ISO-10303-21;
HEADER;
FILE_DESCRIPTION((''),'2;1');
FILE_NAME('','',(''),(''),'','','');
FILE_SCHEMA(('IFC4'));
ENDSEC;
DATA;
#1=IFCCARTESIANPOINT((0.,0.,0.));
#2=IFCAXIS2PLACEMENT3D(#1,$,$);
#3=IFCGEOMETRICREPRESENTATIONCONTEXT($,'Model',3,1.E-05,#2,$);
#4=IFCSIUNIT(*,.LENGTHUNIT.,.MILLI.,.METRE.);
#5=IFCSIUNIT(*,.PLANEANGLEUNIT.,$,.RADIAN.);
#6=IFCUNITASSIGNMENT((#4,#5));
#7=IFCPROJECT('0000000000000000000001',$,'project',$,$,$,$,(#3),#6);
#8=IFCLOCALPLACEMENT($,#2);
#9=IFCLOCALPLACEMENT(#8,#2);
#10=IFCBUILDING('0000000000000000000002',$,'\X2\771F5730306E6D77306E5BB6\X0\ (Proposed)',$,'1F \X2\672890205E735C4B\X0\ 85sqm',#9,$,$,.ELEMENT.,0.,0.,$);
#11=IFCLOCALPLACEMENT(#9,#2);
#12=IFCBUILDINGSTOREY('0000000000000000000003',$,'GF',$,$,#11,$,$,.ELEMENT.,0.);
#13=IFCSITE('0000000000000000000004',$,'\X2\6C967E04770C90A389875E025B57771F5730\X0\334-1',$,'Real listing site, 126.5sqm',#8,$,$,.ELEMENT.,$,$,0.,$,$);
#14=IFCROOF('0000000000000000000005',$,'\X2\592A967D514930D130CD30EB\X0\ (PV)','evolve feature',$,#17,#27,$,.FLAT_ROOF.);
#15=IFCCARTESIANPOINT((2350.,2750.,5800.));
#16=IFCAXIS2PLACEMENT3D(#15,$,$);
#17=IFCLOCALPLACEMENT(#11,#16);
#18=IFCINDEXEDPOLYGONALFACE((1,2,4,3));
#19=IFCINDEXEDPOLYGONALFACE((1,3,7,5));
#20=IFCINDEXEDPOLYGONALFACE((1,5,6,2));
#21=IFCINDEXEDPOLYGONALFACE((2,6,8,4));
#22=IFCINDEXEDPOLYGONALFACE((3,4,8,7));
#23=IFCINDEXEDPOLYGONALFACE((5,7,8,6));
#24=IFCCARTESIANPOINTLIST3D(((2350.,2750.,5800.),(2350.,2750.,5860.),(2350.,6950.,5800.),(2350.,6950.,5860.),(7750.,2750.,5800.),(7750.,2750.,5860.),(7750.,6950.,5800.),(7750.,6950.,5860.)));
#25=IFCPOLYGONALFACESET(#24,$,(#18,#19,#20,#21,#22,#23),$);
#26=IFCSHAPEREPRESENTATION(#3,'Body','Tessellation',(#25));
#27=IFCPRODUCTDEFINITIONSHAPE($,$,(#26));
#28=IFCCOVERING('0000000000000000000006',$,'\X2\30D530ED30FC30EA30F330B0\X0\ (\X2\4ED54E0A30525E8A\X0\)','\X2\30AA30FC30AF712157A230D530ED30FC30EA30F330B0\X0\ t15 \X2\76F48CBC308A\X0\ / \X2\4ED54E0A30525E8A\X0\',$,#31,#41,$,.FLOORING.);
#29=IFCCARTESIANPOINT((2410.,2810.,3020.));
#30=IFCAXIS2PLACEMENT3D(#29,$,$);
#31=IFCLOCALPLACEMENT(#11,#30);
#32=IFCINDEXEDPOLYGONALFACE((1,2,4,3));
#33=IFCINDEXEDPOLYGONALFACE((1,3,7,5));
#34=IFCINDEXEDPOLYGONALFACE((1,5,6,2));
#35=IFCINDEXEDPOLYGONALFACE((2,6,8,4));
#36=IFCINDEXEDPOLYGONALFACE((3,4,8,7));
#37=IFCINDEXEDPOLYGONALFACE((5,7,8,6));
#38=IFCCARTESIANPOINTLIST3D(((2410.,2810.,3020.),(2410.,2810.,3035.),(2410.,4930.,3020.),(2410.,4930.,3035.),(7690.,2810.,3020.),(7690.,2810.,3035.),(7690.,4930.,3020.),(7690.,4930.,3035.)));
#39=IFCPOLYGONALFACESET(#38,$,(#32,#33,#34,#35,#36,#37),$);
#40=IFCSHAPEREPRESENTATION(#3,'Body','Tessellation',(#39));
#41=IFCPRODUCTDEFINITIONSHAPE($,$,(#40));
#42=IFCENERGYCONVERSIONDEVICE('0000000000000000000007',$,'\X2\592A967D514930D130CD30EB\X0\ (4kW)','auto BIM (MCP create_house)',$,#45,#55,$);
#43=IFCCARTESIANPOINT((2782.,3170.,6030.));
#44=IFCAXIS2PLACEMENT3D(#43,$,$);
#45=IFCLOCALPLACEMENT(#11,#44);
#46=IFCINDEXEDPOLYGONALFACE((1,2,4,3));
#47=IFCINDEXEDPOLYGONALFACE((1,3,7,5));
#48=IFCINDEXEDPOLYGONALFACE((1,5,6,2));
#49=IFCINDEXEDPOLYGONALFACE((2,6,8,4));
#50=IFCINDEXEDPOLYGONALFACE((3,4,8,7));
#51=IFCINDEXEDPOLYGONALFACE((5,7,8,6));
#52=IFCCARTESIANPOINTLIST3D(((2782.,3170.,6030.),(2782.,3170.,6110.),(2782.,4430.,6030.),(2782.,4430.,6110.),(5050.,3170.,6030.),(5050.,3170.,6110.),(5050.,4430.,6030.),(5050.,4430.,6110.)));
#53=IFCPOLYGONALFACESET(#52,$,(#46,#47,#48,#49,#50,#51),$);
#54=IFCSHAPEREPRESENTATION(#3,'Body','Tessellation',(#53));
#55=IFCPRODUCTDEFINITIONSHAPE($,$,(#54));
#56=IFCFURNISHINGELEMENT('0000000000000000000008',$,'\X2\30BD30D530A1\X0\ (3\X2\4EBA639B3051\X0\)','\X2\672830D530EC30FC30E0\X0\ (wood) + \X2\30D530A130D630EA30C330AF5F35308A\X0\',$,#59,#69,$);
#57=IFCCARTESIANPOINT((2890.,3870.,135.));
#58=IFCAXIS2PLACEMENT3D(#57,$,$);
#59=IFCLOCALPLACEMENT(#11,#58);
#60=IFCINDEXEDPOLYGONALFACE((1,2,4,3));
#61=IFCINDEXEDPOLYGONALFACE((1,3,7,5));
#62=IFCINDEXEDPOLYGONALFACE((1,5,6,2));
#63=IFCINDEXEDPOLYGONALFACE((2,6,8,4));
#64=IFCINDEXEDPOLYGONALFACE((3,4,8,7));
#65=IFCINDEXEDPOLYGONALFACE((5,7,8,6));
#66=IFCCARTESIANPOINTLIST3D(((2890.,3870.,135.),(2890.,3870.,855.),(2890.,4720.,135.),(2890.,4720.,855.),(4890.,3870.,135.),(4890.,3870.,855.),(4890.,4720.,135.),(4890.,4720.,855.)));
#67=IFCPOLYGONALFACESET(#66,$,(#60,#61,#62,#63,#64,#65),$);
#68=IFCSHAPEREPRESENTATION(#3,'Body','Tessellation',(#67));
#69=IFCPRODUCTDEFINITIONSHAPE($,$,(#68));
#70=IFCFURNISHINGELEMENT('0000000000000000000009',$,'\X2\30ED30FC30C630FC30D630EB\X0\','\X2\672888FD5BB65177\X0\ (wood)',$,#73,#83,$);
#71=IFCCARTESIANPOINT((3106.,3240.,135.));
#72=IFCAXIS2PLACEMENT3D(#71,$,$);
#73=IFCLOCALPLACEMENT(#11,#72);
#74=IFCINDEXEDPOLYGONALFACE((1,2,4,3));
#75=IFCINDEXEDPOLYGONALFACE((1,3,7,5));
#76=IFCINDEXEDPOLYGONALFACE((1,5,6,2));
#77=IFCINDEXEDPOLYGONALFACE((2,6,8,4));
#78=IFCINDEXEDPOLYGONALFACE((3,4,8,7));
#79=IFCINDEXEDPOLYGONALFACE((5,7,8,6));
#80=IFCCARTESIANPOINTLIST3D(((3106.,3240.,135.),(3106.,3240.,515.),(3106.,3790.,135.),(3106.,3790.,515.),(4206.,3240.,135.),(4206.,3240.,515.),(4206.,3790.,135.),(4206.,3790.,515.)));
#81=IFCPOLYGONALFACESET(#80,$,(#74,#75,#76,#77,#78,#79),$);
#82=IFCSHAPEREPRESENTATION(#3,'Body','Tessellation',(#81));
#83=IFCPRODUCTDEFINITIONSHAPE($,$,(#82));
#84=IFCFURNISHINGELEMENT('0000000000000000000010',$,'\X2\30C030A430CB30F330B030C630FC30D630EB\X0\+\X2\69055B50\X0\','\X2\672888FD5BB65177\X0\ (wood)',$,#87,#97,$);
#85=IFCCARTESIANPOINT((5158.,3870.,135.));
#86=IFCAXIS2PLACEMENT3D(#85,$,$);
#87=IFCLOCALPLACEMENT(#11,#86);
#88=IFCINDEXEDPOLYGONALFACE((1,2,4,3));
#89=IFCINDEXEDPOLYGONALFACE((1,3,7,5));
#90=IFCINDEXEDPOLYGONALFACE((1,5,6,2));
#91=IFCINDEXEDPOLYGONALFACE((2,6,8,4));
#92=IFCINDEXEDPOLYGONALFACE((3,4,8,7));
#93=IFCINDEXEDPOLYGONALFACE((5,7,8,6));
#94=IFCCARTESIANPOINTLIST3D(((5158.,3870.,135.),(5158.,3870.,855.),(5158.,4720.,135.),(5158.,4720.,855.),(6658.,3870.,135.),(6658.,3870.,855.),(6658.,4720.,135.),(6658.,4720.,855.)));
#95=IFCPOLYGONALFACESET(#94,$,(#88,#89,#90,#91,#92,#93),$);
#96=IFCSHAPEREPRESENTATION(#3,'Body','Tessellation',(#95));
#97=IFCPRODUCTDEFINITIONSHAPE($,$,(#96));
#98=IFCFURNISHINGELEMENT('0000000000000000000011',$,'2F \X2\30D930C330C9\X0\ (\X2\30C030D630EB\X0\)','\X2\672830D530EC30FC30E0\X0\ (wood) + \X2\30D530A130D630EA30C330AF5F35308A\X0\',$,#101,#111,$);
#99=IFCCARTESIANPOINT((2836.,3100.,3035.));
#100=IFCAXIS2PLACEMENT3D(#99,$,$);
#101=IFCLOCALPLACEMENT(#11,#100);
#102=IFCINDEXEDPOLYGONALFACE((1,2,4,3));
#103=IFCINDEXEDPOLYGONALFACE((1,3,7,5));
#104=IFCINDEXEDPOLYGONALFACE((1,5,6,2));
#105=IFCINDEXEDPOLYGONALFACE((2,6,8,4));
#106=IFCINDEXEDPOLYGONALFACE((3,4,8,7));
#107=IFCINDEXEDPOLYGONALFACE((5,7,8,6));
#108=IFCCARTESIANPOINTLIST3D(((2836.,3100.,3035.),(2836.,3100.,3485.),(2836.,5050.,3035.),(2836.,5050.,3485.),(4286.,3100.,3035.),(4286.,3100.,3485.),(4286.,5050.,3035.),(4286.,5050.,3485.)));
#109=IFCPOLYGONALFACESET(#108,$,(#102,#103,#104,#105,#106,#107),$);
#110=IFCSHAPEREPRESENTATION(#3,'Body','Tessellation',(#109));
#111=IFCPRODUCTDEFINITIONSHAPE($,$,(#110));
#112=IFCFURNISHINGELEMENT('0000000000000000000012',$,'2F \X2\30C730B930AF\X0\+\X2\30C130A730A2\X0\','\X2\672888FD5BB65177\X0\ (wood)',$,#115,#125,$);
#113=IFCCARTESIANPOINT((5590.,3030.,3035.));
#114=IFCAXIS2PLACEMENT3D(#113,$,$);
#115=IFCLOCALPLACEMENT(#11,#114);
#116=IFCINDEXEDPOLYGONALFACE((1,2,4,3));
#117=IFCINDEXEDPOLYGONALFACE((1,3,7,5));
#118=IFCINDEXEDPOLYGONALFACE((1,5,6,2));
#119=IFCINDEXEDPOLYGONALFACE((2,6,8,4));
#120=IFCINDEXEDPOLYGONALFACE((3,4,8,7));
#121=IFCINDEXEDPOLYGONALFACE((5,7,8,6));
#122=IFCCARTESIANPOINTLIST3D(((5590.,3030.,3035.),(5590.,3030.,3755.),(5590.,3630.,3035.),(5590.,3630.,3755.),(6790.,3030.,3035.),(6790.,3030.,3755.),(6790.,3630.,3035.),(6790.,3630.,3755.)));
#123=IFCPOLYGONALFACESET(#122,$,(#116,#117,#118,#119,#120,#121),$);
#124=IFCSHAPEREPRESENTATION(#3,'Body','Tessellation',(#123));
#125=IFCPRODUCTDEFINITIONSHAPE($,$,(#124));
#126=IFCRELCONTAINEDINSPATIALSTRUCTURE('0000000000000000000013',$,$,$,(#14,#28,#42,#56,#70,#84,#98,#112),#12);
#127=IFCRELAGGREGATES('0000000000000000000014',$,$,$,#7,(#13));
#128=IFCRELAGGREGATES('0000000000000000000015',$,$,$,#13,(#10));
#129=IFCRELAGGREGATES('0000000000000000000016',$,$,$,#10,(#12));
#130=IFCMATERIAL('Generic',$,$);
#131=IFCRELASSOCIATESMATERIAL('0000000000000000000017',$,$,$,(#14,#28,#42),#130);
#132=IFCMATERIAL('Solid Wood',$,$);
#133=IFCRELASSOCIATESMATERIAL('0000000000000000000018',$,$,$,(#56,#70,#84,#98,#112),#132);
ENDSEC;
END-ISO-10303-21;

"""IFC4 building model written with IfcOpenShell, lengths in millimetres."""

from ifc_helpers import new_model, si_unit, frame, frame_2d, origin, place, context, project, spatial, rectangle, extrude, material, element, save


model = new_model("IFC4")

# Units and contexts
model_context = context("Model", 3, precision=1e-05, world=origin())
ifc_project = project(units=[si_unit("LENGTHUNIT", "METRE", prefix="MILLI"), si_unit("PLANEANGLEUNIT", "RADIAN")], contexts=[model_context])

# Site, building, storey
site_placement = place(None, origin())
site = spatial("IfcSite", under=ifc_project, at=site_placement, Name="沖縄県那覇市字真地334-1", ObjectType="Real listing site, 126.5sqm", CompositionType="ELEMENT", RefElevation=0.0)
building_placement = place(site_placement, origin())
building = spatial("IfcBuilding", under=site, at=building_placement, Name="真地の海の家 (Proposed)", ObjectType="1F 木造平屋 85sqm", CompositionType="ELEMENT", ElevationOfRefHeight=0.0, ElevationOfTerrain=0.0)
storey_placement = place(building_placement, origin())
storey = spatial("IfcBuildingStorey", under=building, at=storey_placement, Name="GF", CompositionType="ELEMENT", Elevation=0.0)

# Shared definitions
ifc_material_1 = material(Name="Solid Wood")

# Roof
ifc_material_2 = material(Name="Generic")
roof_1_placement = place(storey_placement, frame((2350.0, 2750.0, 5800.0)))
element("IfcRoof", 1, at=roof_1_placement, inside=storey, material=ifc_material_2, Name="太陽光パネル (PV)", Description="evolve feature", PredefinedType="FLAT_ROOF", context=model_context, shape_type="SweptSolid", body=[
    extrude(rectangle(XDim=5400.0, YDim=4200.0, at=frame_2d((2700.0, 2100.0))), frame((2350.0, 2750.0, 5800.0)), (0.0, 0.0, 1.0), 60.0),
])

# Covering
covering_placement = place(storey_placement, frame((2410.0, 2810.0, 3020.0)))
element("IfcCovering", 2, at=covering_placement, inside=storey, material=ifc_material_2, Name="フローリング (仕上げ床)", Description="オーク無垢フローリング t15 直貼り / 仕上げ床", PredefinedType="FLOORING", context=model_context, shape_type="SweptSolid", body=[
    extrude(rectangle(XDim=5280.0, YDim=2120.0, at=frame_2d((2640.0, 1060.0))), frame((2410.0, 2810.0, 3020.0)), (0.0, 0.0, 1.0), 15.0),
])

# Energy conversion device
energy_conversion_device_placement = place(storey_placement, frame((2782.0, 3170.0, 6030.0)))
element("IfcEnergyConversionDevice", 3, at=energy_conversion_device_placement, inside=storey, material=ifc_material_2, Name="太陽光パネル (4kW)", Description="auto BIM (MCP create_house)", context=model_context, shape_type="SweptSolid", body=[
    extrude(rectangle(XDim=2268.0, YDim=1260.0, at=frame_2d((1134.0, 630.0))), frame((2782.0, 3170.0, 6030.0)), (0.0, 0.0, 1.0), 80.0),
])

# Furnishing elements
furnishing_1_placement = place(storey_placement, frame((2890.0, 3870.0, 135.0)))
element("IfcFurnishingElement", 4, at=furnishing_1_placement, inside=storey, material=ifc_material_1, Name="ソファ (3人掛け)", Description="木フレーム (wood) + ファブリック張り", context=model_context, shape_type="SweptSolid", body=[
    extrude(rectangle(XDim=2000.0, YDim=850.0, at=frame_2d((1000.0, 425.0))), frame((2890.0, 3870.0, 135.0)), (0.0, 0.0, 1.0), 720.0),
])
furnishing_2_placement = place(storey_placement, frame((3106.0, 3240.0, 135.0)))
element("IfcFurnishingElement", 5, at=furnishing_2_placement, inside=storey, material=ifc_material_1, Name="ローテーブル", Description="木製家具 (wood)", context=model_context, shape_type="SweptSolid", body=[
    extrude(rectangle(XDim=1100.0, YDim=550.0, at=frame_2d((550.0, 275.0))), frame((3106.0, 3240.0, 135.0)), (0.0, 0.0, 1.0), 380.0),
])
furnishing_3_placement = place(storey_placement, frame((5158.0, 3870.0, 135.0)))
element("IfcFurnishingElement", 6, at=furnishing_3_placement, inside=storey, material=ifc_material_1, Name="ダイニングテーブル+椅子", Description="木製家具 (wood)", context=model_context, shape_type="SweptSolid", body=[
    extrude(rectangle(XDim=1500.0, YDim=850.0, at=frame_2d((750.0, 425.0))), frame((5158.0, 3870.0, 135.0)), (0.0, 0.0, 1.0), 720.0),
])
furnishing_4_placement = place(storey_placement, frame((2836.0, 3100.0, 3035.0)))
element("IfcFurnishingElement", 7, at=furnishing_4_placement, inside=storey, material=ifc_material_1, Name="2F ベッド (ダブル)", Description="木フレーム (wood) + ファブリック張り", context=model_context, shape_type="SweptSolid", body=[
    extrude(rectangle(XDim=1450.0, YDim=1950.0, at=frame_2d((725.0, 975.0))), frame((2836.0, 3100.0, 3035.0)), (0.0, 0.0, 1.0), 450.0),
])
furnishing_5_placement = place(storey_placement, frame((5590.0, 3030.0, 3035.0)))
element("IfcFurnishingElement", 8, at=furnishing_5_placement, inside=storey, material=ifc_material_1, Name="2F デスク+チェア", Description="木製家具 (wood)", context=model_context, shape_type="SweptSolid", body=[
    extrude(rectangle(XDim=1200.0, YDim=600.0, at=frame_2d((600.0, 300.0))), frame((5590.0, 3030.0, 3035.0)), (0.0, 0.0, 1.0), 720.0),
])

save(model, "model.ifc")
